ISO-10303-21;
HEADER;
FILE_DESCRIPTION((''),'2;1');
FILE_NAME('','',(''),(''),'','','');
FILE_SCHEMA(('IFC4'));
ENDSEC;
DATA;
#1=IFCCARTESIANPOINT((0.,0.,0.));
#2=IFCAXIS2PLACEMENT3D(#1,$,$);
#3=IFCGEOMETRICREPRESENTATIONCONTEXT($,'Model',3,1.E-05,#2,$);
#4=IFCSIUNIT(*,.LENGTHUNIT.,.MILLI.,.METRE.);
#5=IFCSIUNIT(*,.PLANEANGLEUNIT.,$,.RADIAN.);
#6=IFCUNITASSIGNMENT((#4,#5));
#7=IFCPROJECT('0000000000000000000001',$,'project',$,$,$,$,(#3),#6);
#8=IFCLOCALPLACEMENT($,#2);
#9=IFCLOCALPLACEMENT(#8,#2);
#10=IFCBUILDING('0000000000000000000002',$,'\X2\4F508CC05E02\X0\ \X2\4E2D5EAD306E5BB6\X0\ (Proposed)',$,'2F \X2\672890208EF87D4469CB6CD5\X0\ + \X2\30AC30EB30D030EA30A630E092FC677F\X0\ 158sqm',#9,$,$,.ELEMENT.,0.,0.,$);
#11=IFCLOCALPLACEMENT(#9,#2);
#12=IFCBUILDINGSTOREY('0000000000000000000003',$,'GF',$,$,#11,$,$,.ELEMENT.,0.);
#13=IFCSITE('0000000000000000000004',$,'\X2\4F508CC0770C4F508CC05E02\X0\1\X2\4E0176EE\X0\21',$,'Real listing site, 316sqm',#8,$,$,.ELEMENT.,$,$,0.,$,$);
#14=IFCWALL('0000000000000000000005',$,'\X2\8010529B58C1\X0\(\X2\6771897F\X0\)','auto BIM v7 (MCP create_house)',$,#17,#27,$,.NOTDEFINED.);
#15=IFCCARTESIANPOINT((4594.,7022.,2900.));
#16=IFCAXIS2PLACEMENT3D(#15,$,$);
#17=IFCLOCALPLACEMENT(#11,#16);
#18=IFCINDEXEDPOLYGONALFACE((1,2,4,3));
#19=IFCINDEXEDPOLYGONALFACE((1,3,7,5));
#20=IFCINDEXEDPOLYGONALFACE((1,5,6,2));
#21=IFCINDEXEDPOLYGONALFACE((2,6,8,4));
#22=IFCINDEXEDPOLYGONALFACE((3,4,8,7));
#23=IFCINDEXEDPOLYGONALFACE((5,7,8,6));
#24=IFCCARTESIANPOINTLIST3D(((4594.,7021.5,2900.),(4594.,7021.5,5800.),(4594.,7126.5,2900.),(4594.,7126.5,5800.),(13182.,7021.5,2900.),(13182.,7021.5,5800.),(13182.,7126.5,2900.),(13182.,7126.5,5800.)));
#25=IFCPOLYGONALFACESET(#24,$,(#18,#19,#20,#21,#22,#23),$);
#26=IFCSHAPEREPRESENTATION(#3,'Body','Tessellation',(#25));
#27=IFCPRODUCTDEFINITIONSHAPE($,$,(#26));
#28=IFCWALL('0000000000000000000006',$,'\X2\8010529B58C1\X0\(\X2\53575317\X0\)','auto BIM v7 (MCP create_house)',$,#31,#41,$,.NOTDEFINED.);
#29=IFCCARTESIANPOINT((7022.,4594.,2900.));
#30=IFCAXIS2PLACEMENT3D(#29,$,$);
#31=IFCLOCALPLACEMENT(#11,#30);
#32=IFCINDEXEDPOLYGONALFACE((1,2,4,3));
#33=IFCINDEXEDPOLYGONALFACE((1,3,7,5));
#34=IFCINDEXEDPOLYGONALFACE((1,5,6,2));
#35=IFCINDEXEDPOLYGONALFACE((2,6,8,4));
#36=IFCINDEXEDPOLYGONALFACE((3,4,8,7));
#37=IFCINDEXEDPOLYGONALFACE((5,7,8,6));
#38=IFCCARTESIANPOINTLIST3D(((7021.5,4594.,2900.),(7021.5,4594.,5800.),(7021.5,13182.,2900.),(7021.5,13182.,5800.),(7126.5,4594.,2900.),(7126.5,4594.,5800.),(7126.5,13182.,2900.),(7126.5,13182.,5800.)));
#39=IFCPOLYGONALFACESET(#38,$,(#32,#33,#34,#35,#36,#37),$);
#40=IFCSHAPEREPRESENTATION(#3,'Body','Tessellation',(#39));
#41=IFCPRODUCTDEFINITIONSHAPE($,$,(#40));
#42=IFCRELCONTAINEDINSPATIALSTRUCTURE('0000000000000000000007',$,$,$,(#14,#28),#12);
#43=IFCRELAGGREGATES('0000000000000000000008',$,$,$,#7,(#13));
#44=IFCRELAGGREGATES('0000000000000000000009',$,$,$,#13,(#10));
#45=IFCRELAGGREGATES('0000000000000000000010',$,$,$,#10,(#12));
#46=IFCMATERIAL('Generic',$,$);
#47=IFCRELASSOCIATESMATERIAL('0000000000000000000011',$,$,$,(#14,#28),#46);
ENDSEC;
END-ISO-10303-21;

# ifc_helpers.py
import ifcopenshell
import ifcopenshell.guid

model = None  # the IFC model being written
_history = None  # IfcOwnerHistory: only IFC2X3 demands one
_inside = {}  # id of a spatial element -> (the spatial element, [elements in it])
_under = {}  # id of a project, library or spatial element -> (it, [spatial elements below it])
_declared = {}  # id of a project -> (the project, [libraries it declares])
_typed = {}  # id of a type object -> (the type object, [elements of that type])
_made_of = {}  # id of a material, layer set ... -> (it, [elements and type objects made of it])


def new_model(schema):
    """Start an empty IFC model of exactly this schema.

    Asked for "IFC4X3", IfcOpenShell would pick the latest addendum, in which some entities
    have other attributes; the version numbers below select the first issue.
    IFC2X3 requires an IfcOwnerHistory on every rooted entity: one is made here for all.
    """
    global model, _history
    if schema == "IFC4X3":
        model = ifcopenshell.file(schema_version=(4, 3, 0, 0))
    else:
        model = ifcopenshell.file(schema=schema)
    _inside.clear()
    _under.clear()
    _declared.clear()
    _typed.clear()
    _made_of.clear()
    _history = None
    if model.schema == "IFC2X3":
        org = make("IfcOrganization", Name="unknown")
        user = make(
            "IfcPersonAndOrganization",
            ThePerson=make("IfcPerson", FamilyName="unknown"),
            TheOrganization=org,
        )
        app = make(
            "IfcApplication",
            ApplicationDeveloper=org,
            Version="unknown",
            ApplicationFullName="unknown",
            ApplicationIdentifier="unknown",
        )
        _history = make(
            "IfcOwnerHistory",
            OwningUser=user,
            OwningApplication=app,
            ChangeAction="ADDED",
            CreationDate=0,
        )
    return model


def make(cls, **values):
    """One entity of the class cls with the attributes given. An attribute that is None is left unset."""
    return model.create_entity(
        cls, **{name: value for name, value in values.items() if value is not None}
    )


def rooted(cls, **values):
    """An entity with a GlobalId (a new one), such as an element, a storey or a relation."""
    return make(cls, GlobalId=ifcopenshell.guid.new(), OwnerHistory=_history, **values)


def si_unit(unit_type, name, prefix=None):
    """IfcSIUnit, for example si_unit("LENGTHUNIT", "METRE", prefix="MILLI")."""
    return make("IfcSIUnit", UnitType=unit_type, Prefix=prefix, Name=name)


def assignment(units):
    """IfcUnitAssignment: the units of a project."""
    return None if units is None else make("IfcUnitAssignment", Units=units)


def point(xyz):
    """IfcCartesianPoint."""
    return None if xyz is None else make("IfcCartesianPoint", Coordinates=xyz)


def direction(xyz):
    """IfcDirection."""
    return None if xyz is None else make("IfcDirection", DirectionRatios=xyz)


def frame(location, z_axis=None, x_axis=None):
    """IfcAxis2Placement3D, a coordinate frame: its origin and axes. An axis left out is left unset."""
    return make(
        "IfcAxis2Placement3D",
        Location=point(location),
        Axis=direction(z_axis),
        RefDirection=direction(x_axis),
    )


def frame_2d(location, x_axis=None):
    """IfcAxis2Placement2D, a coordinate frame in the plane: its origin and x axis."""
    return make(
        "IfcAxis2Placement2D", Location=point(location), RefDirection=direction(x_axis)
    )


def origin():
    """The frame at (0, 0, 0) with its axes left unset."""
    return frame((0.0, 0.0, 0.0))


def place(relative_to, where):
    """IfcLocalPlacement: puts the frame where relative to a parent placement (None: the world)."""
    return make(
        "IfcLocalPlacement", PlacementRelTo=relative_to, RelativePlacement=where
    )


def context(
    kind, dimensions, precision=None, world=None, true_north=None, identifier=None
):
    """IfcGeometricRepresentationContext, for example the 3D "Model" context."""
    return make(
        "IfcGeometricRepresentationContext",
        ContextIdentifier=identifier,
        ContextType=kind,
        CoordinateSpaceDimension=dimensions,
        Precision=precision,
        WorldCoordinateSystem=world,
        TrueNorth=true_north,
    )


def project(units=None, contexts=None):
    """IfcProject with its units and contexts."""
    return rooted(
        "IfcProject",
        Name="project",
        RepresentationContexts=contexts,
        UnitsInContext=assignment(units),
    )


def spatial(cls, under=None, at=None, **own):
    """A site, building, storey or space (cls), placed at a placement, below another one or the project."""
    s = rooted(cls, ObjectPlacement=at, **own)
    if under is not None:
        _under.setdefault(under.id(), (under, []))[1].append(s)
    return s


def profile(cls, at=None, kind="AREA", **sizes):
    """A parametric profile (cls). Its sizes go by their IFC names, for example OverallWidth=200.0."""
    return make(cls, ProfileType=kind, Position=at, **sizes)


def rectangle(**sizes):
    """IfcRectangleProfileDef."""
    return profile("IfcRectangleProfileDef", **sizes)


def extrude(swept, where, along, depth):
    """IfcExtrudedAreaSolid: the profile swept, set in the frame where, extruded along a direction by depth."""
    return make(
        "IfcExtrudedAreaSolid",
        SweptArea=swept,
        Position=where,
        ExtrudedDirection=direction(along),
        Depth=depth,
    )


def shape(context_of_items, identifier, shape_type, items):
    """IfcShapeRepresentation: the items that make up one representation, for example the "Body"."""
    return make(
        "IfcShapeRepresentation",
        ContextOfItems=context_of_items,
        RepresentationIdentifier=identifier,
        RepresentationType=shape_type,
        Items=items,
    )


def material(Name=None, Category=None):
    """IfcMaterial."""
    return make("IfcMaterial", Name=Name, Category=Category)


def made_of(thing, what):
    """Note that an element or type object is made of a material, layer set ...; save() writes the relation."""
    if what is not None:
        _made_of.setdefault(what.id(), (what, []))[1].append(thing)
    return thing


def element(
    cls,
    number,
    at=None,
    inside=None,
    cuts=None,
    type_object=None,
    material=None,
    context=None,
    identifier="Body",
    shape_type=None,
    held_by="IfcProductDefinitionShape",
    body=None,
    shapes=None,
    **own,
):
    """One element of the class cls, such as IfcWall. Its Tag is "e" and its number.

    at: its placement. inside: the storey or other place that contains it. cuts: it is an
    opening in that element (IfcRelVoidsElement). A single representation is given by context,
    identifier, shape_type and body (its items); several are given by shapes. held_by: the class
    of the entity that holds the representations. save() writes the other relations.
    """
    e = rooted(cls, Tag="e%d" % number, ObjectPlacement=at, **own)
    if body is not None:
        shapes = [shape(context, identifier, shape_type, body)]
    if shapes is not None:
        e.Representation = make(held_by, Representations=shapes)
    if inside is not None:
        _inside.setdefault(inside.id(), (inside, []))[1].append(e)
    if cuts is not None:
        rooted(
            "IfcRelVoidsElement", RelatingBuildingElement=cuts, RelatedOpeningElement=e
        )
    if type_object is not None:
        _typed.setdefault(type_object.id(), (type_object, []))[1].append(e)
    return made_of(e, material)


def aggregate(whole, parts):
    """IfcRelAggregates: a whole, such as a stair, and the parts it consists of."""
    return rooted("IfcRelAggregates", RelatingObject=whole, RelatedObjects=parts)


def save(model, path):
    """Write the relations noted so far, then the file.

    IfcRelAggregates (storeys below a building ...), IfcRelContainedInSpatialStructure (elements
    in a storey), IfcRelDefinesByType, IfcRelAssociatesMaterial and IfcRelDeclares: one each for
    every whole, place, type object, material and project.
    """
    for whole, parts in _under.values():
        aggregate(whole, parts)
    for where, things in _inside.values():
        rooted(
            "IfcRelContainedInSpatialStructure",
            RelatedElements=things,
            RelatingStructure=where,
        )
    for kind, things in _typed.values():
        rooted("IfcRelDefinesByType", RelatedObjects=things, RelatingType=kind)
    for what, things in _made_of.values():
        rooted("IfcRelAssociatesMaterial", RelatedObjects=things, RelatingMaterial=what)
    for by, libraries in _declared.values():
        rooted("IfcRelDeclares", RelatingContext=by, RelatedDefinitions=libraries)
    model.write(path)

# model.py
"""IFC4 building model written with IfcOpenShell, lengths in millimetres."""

from ifc_helpers import new_model, si_unit, frame, frame_2d, origin, place, context, project, spatial, rectangle, extrude, material, element, save


model = new_model("IFC4")

# Units and contexts
model_context = context("Model", 3, precision=1e-05, world=origin())
ifc_project = project(units=[si_unit("LENGTHUNIT", "METRE", prefix="MILLI"), si_unit("PLANEANGLEUNIT", "RADIAN")], contexts=[model_context])

# Site, building, storey
site_placement = place(None, origin())
site = spatial("IfcSite", under=ifc_project, at=site_placement, Name="佐賀県佐賀市1丁目21", ObjectType="Real listing site, 316sqm", CompositionType="ELEMENT", RefElevation=0.0)
building_placement = place(site_placement, origin())
building = spatial("IfcBuilding", under=site, at=building_placement, Name="佐賀市 中庭の家 (Proposed)", ObjectType="2F 木造軸組構法 + ガルバリウム鋼板 158sqm", CompositionType="ELEMENT", ElevationOfRefHeight=0.0, ElevationOfTerrain=0.0)
storey_placement = place(building_placement, origin())
storey = spatial("IfcBuildingStorey", under=building, at=storey_placement, Name="GF", CompositionType="ELEMENT", Elevation=0.0)

# Shared definitions
ifc_material = material(Name="Generic")

# Walls
wall_1_placement = place(storey_placement, frame((4594.0, 7022.0, 2900.0)))
element("IfcWall", 1, at=wall_1_placement, inside=storey, material=ifc_material, Name="耐力壁(東西)", Description="auto BIM v7 (MCP create_house)", PredefinedType="NOTDEFINED", context=model_context, shape_type="SweptSolid", body=[
    extrude(rectangle(XDim=8588.0, YDim=105.0, at=frame_2d((4294.0, 52.0))), frame((4594.0, 7022.0, 2900.0)), (0.0, 0.0, 1.0), 2900.0),
])
wall_2_placement = place(storey_placement, frame((7022.0, 4594.0, 2900.0)))
element("IfcWall", 2, at=wall_2_placement, inside=storey, material=ifc_material, Name="耐力壁(南北)", Description="auto BIM v7 (MCP create_house)", PredefinedType="NOTDEFINED", context=model_context, shape_type="SweptSolid", body=[
    extrude(rectangle(XDim=105.0, YDim=8588.0, at=frame_2d((52.0, 4294.0))), frame((7022.0, 4594.0, 2900.0)), (0.0, 0.0, 1.0), 2900.0),
])

save(model, "model.ifc")
